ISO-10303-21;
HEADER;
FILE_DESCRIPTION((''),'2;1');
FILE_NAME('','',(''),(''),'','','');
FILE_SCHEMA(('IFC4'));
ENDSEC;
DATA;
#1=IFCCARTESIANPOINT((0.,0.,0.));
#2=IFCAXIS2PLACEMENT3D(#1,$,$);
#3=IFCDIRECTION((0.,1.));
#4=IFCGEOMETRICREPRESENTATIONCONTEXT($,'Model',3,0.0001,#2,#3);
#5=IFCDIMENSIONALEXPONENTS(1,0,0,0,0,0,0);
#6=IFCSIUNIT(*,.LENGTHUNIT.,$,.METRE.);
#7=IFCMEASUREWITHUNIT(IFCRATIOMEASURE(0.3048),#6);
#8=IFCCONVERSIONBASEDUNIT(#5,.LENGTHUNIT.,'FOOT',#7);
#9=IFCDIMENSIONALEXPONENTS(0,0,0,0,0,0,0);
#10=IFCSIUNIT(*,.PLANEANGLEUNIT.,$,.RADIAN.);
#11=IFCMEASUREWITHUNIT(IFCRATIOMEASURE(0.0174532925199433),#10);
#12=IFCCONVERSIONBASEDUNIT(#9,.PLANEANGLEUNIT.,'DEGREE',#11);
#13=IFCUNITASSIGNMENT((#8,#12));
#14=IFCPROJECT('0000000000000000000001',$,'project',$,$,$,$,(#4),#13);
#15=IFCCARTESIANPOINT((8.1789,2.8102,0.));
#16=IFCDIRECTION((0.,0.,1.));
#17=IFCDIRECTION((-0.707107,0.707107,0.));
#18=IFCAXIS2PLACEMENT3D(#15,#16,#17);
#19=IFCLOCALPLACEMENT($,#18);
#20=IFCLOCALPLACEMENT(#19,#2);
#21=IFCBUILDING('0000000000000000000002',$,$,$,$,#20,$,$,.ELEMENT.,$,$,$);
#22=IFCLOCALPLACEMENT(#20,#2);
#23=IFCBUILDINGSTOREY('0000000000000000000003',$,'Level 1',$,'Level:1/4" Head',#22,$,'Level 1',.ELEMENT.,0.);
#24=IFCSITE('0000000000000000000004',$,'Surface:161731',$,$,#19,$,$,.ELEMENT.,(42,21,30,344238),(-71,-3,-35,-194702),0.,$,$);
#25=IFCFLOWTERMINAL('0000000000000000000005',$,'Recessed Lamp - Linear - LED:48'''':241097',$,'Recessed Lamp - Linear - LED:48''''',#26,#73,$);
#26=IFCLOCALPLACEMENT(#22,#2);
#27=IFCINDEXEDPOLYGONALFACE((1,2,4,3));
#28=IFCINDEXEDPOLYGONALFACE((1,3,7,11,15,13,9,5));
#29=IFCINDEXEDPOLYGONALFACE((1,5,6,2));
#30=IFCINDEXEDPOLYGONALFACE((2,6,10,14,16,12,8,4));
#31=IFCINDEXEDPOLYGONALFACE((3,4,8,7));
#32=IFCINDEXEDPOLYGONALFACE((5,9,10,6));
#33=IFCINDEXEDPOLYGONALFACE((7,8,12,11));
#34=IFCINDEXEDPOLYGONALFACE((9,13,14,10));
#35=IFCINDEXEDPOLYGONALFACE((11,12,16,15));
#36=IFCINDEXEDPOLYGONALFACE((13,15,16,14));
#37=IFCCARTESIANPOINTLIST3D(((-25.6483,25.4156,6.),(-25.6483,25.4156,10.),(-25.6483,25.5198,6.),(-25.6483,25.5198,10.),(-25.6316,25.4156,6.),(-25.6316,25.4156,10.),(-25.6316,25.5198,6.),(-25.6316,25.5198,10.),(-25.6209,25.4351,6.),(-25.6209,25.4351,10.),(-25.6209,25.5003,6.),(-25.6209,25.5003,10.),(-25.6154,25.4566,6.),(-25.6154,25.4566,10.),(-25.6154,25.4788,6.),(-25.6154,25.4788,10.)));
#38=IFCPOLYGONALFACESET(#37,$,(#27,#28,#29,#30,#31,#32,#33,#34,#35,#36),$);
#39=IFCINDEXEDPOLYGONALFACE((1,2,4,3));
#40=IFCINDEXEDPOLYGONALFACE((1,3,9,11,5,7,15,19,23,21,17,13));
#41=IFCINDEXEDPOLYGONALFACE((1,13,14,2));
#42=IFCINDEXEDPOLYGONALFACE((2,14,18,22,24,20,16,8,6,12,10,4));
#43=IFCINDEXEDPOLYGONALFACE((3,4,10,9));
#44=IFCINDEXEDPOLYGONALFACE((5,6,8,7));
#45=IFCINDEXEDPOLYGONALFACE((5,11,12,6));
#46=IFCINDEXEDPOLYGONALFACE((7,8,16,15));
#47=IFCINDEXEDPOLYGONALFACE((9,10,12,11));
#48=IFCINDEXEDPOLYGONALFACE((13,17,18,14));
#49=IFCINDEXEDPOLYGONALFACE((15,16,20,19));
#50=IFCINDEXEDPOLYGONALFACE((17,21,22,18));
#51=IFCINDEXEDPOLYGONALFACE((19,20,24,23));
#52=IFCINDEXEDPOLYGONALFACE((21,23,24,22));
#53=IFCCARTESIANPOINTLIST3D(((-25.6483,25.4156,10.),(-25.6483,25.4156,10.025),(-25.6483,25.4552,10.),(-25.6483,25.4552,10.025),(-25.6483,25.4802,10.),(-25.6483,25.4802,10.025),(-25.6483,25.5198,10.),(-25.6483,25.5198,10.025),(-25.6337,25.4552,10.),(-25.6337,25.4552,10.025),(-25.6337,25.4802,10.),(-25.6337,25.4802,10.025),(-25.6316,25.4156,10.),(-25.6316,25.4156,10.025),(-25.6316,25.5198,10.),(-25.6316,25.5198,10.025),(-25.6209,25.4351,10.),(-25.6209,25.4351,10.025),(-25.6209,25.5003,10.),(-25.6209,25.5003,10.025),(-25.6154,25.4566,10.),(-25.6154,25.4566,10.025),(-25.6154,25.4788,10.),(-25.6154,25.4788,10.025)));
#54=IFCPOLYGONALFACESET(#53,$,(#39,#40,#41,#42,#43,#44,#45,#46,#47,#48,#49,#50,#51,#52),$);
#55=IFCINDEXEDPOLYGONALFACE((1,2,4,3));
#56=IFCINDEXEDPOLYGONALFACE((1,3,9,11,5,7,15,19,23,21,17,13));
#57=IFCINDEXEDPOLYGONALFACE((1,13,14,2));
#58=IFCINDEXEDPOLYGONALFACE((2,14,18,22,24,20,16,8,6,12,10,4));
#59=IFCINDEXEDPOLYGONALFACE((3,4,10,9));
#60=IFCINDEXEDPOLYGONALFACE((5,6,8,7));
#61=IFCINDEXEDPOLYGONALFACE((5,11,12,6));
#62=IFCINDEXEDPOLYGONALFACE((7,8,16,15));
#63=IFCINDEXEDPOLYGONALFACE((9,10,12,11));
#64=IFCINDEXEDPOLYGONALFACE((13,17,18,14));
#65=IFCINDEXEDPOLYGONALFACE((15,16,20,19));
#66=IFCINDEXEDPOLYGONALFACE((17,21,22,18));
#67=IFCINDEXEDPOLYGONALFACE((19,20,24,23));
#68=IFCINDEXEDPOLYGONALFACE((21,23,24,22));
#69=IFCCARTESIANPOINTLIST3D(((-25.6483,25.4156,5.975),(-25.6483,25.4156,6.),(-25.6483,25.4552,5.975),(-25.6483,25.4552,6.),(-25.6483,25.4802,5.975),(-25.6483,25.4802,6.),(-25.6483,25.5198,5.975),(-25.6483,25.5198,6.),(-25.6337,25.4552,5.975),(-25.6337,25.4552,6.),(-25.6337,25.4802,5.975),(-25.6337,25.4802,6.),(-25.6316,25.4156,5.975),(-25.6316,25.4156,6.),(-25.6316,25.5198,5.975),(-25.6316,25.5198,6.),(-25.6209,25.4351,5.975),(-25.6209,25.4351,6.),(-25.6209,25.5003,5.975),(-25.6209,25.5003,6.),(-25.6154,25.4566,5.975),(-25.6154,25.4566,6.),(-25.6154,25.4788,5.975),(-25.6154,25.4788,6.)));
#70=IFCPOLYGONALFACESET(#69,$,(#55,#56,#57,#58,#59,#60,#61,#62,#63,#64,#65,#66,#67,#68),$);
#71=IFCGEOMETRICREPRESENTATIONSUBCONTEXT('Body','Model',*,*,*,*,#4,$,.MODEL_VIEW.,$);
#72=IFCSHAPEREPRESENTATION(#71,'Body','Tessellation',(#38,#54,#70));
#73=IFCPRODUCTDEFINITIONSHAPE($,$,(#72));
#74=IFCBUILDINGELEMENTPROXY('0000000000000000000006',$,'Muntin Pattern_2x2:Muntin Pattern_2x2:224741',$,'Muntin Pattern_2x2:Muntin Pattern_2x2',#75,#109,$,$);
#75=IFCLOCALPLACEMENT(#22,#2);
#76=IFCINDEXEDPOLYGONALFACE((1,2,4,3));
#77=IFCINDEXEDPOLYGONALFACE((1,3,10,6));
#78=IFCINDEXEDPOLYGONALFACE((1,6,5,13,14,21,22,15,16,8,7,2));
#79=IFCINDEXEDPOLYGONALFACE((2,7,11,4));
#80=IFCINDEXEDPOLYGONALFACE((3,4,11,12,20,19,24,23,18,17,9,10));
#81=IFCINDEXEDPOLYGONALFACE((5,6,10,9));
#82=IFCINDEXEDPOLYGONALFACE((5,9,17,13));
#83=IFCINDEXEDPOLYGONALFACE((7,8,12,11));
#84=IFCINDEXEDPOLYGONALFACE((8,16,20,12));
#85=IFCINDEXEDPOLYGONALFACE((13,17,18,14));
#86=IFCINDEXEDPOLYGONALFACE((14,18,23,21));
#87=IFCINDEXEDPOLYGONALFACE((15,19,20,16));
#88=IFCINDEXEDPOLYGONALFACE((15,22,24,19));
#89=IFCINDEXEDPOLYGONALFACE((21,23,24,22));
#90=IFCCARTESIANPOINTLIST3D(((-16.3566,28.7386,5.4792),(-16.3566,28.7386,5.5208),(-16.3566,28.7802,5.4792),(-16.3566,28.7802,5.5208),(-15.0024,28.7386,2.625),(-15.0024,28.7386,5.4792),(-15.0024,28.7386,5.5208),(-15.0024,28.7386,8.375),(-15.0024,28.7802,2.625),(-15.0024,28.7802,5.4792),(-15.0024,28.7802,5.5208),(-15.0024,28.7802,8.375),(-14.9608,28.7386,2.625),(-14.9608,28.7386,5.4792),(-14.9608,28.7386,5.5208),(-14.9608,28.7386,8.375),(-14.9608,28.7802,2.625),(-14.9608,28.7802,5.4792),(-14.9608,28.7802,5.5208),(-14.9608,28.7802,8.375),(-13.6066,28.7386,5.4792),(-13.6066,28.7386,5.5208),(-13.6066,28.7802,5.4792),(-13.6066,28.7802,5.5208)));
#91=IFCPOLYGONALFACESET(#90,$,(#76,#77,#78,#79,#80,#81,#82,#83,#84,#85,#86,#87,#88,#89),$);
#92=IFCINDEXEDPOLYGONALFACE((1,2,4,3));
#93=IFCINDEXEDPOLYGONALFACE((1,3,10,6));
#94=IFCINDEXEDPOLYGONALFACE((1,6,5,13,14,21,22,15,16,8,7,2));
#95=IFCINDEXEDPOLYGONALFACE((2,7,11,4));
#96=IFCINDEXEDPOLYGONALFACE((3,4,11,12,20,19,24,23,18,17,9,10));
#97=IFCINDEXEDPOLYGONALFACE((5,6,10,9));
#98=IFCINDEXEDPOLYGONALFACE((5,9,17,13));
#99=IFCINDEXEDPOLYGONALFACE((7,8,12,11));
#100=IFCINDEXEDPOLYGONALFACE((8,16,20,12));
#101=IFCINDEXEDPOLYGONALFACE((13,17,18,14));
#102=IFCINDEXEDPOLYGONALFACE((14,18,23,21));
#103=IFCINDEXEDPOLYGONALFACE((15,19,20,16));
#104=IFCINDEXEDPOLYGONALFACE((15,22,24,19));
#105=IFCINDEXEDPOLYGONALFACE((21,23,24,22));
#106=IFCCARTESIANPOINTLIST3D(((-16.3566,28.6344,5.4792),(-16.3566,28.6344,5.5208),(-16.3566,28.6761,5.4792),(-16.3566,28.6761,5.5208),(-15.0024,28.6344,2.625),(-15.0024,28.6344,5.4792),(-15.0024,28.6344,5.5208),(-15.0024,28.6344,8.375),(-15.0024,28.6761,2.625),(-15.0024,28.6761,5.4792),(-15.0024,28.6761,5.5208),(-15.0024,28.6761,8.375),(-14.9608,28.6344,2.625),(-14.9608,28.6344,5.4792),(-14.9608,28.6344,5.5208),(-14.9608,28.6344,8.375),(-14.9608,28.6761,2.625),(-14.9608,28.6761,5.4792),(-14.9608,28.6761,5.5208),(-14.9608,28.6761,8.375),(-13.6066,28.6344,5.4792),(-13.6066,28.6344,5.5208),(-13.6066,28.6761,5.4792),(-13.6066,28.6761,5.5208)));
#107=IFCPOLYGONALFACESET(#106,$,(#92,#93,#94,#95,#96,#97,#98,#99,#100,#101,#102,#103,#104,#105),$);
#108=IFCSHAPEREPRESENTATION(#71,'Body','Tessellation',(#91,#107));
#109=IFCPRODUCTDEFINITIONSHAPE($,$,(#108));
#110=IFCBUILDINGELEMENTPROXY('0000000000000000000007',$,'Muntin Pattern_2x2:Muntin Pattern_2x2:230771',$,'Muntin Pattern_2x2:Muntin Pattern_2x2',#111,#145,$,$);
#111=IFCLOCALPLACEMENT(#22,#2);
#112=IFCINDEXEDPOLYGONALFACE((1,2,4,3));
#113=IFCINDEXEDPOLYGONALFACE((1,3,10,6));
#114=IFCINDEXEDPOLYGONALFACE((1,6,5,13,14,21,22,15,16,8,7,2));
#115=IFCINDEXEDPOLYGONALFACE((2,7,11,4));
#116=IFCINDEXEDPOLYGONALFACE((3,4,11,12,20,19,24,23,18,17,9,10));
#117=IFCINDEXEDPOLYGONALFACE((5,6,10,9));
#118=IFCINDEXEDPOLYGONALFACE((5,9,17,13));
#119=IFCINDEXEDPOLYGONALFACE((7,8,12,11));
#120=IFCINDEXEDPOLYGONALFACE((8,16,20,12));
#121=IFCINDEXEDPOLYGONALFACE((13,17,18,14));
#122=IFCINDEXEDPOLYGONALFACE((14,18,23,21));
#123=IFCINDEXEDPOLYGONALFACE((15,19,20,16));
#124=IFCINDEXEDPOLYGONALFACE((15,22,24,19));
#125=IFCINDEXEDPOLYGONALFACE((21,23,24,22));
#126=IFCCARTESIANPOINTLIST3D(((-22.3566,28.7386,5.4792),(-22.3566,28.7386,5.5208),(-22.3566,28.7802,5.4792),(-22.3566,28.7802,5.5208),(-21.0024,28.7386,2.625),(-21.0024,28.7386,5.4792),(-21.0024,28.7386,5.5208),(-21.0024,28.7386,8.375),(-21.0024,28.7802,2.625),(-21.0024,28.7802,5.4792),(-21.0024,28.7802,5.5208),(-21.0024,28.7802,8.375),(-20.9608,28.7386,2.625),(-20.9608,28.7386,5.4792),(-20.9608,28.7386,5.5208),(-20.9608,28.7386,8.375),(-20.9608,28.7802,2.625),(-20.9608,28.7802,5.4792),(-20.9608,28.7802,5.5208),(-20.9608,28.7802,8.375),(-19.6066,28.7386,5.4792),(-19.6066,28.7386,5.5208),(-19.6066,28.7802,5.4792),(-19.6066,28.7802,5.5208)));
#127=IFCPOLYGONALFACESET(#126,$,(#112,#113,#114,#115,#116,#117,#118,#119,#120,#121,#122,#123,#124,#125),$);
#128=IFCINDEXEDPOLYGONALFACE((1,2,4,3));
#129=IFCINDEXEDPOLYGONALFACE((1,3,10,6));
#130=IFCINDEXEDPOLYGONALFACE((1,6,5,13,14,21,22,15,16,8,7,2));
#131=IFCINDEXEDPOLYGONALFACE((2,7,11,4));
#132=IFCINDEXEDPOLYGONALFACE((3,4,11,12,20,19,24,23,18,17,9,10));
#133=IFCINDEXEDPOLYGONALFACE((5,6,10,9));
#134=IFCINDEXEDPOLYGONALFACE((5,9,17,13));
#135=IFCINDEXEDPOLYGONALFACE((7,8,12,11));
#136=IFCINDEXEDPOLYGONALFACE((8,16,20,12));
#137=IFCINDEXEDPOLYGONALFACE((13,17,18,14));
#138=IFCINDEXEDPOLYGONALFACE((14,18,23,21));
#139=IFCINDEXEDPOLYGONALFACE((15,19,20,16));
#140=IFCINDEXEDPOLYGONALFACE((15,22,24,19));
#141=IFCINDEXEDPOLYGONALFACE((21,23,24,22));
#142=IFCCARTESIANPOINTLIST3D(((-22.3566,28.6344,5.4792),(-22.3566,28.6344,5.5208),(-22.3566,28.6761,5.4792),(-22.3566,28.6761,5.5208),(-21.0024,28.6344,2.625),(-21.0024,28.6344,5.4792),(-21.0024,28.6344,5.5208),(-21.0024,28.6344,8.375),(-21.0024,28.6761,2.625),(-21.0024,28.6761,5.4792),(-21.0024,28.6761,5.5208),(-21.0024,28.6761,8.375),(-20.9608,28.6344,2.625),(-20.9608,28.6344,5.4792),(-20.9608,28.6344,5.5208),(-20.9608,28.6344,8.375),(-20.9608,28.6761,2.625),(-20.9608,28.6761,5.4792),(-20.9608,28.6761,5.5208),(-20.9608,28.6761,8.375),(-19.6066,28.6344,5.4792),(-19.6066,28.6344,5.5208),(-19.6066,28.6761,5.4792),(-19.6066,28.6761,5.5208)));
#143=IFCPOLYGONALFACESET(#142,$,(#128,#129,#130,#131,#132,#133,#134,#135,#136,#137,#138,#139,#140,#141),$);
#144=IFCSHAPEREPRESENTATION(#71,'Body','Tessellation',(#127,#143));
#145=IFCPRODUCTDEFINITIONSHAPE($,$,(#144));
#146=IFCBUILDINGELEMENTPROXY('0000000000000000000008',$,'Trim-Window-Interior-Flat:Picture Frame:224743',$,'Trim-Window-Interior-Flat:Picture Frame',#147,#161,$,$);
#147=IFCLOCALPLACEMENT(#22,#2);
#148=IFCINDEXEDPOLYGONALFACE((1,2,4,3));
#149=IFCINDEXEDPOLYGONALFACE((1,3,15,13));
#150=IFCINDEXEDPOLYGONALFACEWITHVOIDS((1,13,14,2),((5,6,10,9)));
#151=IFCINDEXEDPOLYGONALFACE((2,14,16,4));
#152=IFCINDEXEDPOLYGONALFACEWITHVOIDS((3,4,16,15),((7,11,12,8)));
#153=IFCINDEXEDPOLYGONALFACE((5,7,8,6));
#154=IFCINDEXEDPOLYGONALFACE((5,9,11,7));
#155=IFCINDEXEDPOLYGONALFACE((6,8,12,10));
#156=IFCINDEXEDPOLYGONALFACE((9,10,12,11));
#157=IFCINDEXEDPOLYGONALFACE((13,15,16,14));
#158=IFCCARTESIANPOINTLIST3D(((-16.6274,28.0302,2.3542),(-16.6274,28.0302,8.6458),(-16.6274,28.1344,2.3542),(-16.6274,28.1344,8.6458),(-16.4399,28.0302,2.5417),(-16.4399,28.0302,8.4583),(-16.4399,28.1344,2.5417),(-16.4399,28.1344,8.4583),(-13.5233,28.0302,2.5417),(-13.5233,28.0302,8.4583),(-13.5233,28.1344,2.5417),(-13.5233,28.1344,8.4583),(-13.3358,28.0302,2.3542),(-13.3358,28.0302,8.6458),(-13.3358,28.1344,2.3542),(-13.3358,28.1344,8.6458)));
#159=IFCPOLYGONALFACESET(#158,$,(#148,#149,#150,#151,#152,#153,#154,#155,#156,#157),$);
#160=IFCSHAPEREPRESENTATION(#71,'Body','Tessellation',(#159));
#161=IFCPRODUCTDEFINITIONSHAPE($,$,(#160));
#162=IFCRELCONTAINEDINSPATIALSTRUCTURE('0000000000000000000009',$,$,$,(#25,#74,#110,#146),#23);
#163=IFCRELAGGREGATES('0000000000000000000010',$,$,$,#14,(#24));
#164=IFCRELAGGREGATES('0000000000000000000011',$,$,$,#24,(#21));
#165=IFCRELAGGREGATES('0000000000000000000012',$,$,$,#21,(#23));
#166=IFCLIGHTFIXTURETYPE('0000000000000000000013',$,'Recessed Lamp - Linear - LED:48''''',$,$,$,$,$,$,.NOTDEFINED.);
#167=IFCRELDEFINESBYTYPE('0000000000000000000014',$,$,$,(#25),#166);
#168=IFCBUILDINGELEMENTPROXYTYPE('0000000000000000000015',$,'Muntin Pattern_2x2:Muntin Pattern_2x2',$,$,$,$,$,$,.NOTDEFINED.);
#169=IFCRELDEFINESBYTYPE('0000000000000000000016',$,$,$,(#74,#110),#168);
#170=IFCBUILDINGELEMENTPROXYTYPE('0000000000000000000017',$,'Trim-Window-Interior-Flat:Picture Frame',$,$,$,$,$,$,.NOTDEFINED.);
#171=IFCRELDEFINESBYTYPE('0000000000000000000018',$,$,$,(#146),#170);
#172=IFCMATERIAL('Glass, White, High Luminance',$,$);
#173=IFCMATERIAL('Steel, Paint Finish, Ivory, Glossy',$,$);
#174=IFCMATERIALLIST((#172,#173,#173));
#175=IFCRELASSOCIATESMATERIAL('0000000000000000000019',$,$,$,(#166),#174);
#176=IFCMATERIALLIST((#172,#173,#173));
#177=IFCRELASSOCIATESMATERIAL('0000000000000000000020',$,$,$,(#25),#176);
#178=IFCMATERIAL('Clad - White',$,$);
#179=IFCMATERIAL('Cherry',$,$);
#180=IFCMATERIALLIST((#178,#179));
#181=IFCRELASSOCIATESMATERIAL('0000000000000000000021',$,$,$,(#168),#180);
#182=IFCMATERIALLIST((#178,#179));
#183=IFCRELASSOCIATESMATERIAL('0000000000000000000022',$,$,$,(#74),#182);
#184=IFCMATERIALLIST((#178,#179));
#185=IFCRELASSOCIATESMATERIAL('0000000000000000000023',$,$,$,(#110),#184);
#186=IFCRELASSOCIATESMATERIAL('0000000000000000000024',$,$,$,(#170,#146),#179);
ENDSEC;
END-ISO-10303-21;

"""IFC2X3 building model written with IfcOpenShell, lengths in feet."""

from ifc_helpers import new_model, entity, si_unit, converted_unit, direction, frame, frame_2d, origin, place, context, subcontext, project, spatial, polyline, circle_curve, parameter, trimmed, segment, composite_curve, outline, extrude, source, transform, mapped, material, material_list, type_object, type_shapes, element, save


model = new_model("IFC2X3")

# Units and contexts
model_context = context("Model", 3, precision=0.0001, world=origin(), true_north=direction((0.0, 1.0)))
body_context = subcontext(model_context, "Body", "Model", "MODEL_VIEW")
ifc_project = project(units=[converted_unit("LENGTHUNIT", "FOOT", entity("IfcRatioMeasure", 0.3048), si_unit("LENGTHUNIT", "METRE"), dimensions=[1, 0, 0, 0, 0, 0, 0]), converted_unit("PLANEANGLEUNIT", "DEGREE", entity("IfcRatioMeasure", 0.0174532925199433), si_unit("PLANEANGLEUNIT", "RADIAN"), dimensions=[0, 0, 0, 0, 0, 0, 0])], contexts=[model_context])

# Site, building, storey
site_placement = place(None, frame((8.1789, 2.8102, 0.0), z_axis=(0.0, 0.0, 1.0), x_axis=(-0.707107, 0.707107, 0.0)))
site = spatial("IfcSite", under=ifc_project, at=site_placement, Name="Surface:161731", CompositionType="ELEMENT", RefLatitude=(42, 21, 30, 344238), RefLongitude=(-71, -3, -35, -194702), RefElevation=0.0)
building_placement = place(site_placement, origin())
building = spatial("IfcBuilding", under=site, at=building_placement, CompositionType="ELEMENT")
storey_placement = place(building_placement, origin())
storey = spatial("IfcBuildingStorey", under=building, at=storey_placement, Name="Level 1", ObjectType="Level:1/4\" Head", LongName="Level 1", CompositionType="ELEMENT", Elevation=0.0)

# Flow terminal
ifc_material_1 = material(Name="Glass, White, High Luminance")
ifc_material_2 = material(Name="Steel, Paint Finish, Ivory, Glossy")
ifc_material_list_1 = material_list([ifc_material_1, ifc_material_2, ifc_material_2])
ifc_material_list_2 = material_list([ifc_material_1, ifc_material_2, ifc_material_2])
light_fixture_type_1 = type_object("IfcLightFixtureType", Name="Recessed Lamp - Linear - LED:48''", PredefinedType="NOTDEFINED", material=ifc_material_list_2)
shared_shape_1 = source(origin(), body_context, "Body", "SweptSolid", [
    extrude(outline(composite_curve([segment(trimmed(circle_curve(frame_2d((0.0, -0.0639), x_axis=(1.0, 0.0)), 0.089), [parameter(54.196986)], [parameter(125.803014)], True, "PARAMETER"), True, "CONTINUOUS"), segment(polyline([(-0.0521, 0.0083), (-0.0521, -0.0083)]), True, "CONTINUOUS"), segment(polyline([(-0.0521, -0.0083), (0.0521, -0.0083)]), True, "CONTINUOUS"), segment(polyline([(0.0521, -0.0083), (0.0521, 0.0083)]), True, "CONTINUOUS")], self_intersect=False)), frame((-2.0, 0.0, 0.0083), z_axis=(1.0, 0.0, 0.0), x_axis=(0.0, 1.0, 0.0)), (0.0, 0.0, 1.0), 4.0),
    extrude(outline(composite_curve([segment(trimmed(circle_curve(frame_2d((0.0, -0.0633), x_axis=(1.0, 0.0)), 0.089), [parameter(54.196986)], [parameter(125.803014)], True, "PARAMETER"), True, "CONTINUOUS"), segment(polyline([(-0.0521, 0.0089), (-0.0521, -0.0078)]), True, "CONTINUOUS"), segment(polyline([(-0.0521, -0.0078), (-0.0125, -0.0078)]), True, "CONTINUOUS"), segment(polyline([(-0.0125, -0.0078), (-0.0125, 0.0068)]), True, "CONTINUOUS"), segment(polyline([(-0.0125, 0.0068), (0.0125, 0.0068)]), True, "CONTINUOUS"), segment(polyline([(0.0125, 0.0068), (0.0125, -0.0078)]), True, "CONTINUOUS"), segment(polyline([(0.0125, -0.0078), (0.0521, -0.0078)]), True, "CONTINUOUS"), segment(polyline([(0.0521, -0.0078), (0.0521, 0.0089)]), True, "CONTINUOUS")], self_intersect=False)), frame((2.0, 0.0, 0.0078), z_axis=(1.0, 0.0, 0.0), x_axis=(0.0, 1.0, 0.0)), (0.0, 0.0, 1.0), 0.025),
    extrude(outline(composite_curve([segment(trimmed(circle_curve(frame_2d((0.0, -0.0633), x_axis=(1.0, 0.0)), 0.089), [parameter(54.196986)], [parameter(125.803014)], True, "PARAMETER"), True, "CONTINUOUS"), segment(polyline([(-0.0521, 0.0089), (-0.0521, -0.0078)]), True, "CONTINUOUS"), segment(polyline([(-0.0521, -0.0078), (-0.0125, -0.0078)]), True, "CONTINUOUS"), segment(polyline([(-0.0125, -0.0078), (-0.0125, 0.0068)]), True, "CONTINUOUS"), segment(polyline([(-0.0125, 0.0068), (0.0125, 0.0068)]), True, "CONTINUOUS"), segment(polyline([(0.0125, 0.0068), (0.0125, -0.0078)]), True, "CONTINUOUS"), segment(polyline([(0.0125, -0.0078), (0.0521, -0.0078)]), True, "CONTINUOUS"), segment(polyline([(0.0521, -0.0078), (0.0521, 0.0089)]), True, "CONTINUOUS")], self_intersect=False)), frame((-2.025, 0.0, 0.0078), z_axis=(1.0, 0.0, 0.0), x_axis=(0.0, 1.0, 0.0)), (0.0, 0.0, 1.0), 0.025),
])
type_shapes(light_fixture_type_1, [shared_shape_1])
flow_terminal_1_placement = place(storey_placement, frame((-25.6483, 25.4677, 8.0), z_axis=(1.0, 0.0, 0.0), x_axis=(0.0, 0.0, 1.0)))
element("IfcFlowTerminal", 1, at=flow_terminal_1_placement, inside=storey, type_object=light_fixture_type_1, material=ifc_material_list_1, Name="Recessed Lamp - Linear - LED:48'':241097", ObjectType="Recessed Lamp - Linear - LED:48''", context=body_context, shape_type="MappedRepresentation", body=[
    mapped(shared_shape_1, transform((0.0, 0.0, 0.0), scale=1.0)),
])

# Building element proxies
ifc_material_3 = material(Name="Clad - White")
ifc_material_4 = material(Name="Cherry")
ifc_material_list_3 = material_list([ifc_material_3, ifc_material_4])
ifc_material_list_4 = material_list([ifc_material_3, ifc_material_4])
building_element_proxy_type_1 = type_object("IfcBuildingElementProxyType", Name="Muntin Pattern_2x2:Muntin Pattern_2x2", PredefinedType="NOTDEFINED", material=ifc_material_list_4)
shared_shape_2 = source(origin(), body_context, "Body", "SweptSolid", [
    extrude(outline(polyline([(0.0208, -0.0208), (2.875, -0.0208), (2.875, 0.0208), (0.0208, 0.0208), (0.0208, 1.375), (-0.0208, 1.375), (-0.0208, 0.0208), (-2.875, 0.0208), (-2.875, -0.0208), (-0.0208, -0.0208), (-0.0208, -1.375), (0.0208, -1.375), (0.0208, -0.0208)])), frame((0.0, -0.0729, 2.875), z_axis=(0.0, 1.0, 0.0), x_axis=(0.0, 0.0, 1.0)), (0.0, 0.0, 1.0), 0.0417),
    extrude(outline(polyline([(0.0208, -0.0208), (2.875, -0.0208), (2.875, 0.0208), (0.0208, 0.0208), (0.0208, 1.375), (-0.0208, 1.375), (-0.0208, 0.0208), (-2.875, 0.0208), (-2.875, -0.0208), (-0.0208, -0.0208), (-0.0208, -1.375), (0.0208, -1.375), (0.0208, -0.0208)])), frame((0.0, 0.0313, 2.875), z_axis=(0.0, 1.0, 0.0), x_axis=(0.0, 0.0, 1.0)), (0.0, 0.0, 1.0), 0.0417),
])
type_shapes(building_element_proxy_type_1, [shared_shape_2])
proxy_1_placement = place(storey_placement, frame((-14.9816, 28.7073, 2.625), z_axis=(0.0, 0.0, 1.0), x_axis=(-1.0, 0.0, 0.0)))
element("IfcBuildingElementProxy", 2, at=proxy_1_placement, inside=storey, type_object=building_element_proxy_type_1, material=ifc_material_list_3, Name="Muntin Pattern_2x2:Muntin Pattern_2x2:224741", ObjectType="Muntin Pattern_2x2:Muntin Pattern_2x2", context=body_context, shape_type="MappedRepresentation", body=[
    mapped(shared_shape_2, transform((0.0, 0.0, 0.0), scale=1.0)),
])
ifc_material_list_5 = material_list([ifc_material_3, ifc_material_4])
proxy_2_placement = place(storey_placement, frame((-20.9816, 28.7073, 2.625), z_axis=(0.0, 0.0, 1.0), x_axis=(-1.0, 0.0, 0.0)))
element("IfcBuildingElementProxy", 3, at=proxy_2_placement, inside=storey, type_object=building_element_proxy_type_1, material=ifc_material_list_5, Name="Muntin Pattern_2x2:Muntin Pattern_2x2:230771", ObjectType="Muntin Pattern_2x2:Muntin Pattern_2x2", context=body_context, shape_type="MappedRepresentation", body=[
    mapped(shared_shape_2, transform((0.0, 0.0, 0.0), scale=1.0)),
])
building_element_proxy_type_2 = type_object("IfcBuildingElementProxyType", Name="Trim-Window-Interior-Flat:Picture Frame", PredefinedType="NOTDEFINED", material=ifc_material_4)
shared_shape_3 = source(origin(), body_context, "Body", "SweptSolid", [
    extrude(outline(polyline([(-1.6458, -3.1458), (1.6458, -3.1458), (1.6458, 3.1458), (-1.6458, 3.1458), (-1.6458, -3.1458)]), holes=[polyline([(-1.4583, -2.9583), (-1.4583, 2.9583), (1.4583, 2.9583), (1.4583, -2.9583), (-1.4583, -2.9583)])]), frame((0.0, -3.0, 0.0), z_axis=(0.0, 0.0, 1.0), x_axis=(-1.0, 0.0, 0.0)), (0.0, 0.0, 1.0), 0.1042),
])
type_shapes(building_element_proxy_type_2, [shared_shape_3])
for number, where, z_axis, x_axis, name in (
    (4, (-14.9816, 28.1344, 8.5), (0.0, -1.0, 0.0), (1.0, 0.0, 0.0), "Trim-Window-Interior-Flat:Picture Frame:224743"),
):
    element("IfcBuildingElementProxy", number, at=place(storey_placement, frame(where, z_axis=z_axis, x_axis=x_axis)), inside=storey, type_object=building_element_proxy_type_2, material=ifc_material_4, Name=name, ObjectType="Trim-Window-Interior-Flat:Picture Frame", context=body_context, shape_type="MappedRepresentation", body=[
        mapped(shared_shape_3, transform((0.0, 0.0, 0.0), scale=1.0)),
    ])

save(model, "model.ifc")
